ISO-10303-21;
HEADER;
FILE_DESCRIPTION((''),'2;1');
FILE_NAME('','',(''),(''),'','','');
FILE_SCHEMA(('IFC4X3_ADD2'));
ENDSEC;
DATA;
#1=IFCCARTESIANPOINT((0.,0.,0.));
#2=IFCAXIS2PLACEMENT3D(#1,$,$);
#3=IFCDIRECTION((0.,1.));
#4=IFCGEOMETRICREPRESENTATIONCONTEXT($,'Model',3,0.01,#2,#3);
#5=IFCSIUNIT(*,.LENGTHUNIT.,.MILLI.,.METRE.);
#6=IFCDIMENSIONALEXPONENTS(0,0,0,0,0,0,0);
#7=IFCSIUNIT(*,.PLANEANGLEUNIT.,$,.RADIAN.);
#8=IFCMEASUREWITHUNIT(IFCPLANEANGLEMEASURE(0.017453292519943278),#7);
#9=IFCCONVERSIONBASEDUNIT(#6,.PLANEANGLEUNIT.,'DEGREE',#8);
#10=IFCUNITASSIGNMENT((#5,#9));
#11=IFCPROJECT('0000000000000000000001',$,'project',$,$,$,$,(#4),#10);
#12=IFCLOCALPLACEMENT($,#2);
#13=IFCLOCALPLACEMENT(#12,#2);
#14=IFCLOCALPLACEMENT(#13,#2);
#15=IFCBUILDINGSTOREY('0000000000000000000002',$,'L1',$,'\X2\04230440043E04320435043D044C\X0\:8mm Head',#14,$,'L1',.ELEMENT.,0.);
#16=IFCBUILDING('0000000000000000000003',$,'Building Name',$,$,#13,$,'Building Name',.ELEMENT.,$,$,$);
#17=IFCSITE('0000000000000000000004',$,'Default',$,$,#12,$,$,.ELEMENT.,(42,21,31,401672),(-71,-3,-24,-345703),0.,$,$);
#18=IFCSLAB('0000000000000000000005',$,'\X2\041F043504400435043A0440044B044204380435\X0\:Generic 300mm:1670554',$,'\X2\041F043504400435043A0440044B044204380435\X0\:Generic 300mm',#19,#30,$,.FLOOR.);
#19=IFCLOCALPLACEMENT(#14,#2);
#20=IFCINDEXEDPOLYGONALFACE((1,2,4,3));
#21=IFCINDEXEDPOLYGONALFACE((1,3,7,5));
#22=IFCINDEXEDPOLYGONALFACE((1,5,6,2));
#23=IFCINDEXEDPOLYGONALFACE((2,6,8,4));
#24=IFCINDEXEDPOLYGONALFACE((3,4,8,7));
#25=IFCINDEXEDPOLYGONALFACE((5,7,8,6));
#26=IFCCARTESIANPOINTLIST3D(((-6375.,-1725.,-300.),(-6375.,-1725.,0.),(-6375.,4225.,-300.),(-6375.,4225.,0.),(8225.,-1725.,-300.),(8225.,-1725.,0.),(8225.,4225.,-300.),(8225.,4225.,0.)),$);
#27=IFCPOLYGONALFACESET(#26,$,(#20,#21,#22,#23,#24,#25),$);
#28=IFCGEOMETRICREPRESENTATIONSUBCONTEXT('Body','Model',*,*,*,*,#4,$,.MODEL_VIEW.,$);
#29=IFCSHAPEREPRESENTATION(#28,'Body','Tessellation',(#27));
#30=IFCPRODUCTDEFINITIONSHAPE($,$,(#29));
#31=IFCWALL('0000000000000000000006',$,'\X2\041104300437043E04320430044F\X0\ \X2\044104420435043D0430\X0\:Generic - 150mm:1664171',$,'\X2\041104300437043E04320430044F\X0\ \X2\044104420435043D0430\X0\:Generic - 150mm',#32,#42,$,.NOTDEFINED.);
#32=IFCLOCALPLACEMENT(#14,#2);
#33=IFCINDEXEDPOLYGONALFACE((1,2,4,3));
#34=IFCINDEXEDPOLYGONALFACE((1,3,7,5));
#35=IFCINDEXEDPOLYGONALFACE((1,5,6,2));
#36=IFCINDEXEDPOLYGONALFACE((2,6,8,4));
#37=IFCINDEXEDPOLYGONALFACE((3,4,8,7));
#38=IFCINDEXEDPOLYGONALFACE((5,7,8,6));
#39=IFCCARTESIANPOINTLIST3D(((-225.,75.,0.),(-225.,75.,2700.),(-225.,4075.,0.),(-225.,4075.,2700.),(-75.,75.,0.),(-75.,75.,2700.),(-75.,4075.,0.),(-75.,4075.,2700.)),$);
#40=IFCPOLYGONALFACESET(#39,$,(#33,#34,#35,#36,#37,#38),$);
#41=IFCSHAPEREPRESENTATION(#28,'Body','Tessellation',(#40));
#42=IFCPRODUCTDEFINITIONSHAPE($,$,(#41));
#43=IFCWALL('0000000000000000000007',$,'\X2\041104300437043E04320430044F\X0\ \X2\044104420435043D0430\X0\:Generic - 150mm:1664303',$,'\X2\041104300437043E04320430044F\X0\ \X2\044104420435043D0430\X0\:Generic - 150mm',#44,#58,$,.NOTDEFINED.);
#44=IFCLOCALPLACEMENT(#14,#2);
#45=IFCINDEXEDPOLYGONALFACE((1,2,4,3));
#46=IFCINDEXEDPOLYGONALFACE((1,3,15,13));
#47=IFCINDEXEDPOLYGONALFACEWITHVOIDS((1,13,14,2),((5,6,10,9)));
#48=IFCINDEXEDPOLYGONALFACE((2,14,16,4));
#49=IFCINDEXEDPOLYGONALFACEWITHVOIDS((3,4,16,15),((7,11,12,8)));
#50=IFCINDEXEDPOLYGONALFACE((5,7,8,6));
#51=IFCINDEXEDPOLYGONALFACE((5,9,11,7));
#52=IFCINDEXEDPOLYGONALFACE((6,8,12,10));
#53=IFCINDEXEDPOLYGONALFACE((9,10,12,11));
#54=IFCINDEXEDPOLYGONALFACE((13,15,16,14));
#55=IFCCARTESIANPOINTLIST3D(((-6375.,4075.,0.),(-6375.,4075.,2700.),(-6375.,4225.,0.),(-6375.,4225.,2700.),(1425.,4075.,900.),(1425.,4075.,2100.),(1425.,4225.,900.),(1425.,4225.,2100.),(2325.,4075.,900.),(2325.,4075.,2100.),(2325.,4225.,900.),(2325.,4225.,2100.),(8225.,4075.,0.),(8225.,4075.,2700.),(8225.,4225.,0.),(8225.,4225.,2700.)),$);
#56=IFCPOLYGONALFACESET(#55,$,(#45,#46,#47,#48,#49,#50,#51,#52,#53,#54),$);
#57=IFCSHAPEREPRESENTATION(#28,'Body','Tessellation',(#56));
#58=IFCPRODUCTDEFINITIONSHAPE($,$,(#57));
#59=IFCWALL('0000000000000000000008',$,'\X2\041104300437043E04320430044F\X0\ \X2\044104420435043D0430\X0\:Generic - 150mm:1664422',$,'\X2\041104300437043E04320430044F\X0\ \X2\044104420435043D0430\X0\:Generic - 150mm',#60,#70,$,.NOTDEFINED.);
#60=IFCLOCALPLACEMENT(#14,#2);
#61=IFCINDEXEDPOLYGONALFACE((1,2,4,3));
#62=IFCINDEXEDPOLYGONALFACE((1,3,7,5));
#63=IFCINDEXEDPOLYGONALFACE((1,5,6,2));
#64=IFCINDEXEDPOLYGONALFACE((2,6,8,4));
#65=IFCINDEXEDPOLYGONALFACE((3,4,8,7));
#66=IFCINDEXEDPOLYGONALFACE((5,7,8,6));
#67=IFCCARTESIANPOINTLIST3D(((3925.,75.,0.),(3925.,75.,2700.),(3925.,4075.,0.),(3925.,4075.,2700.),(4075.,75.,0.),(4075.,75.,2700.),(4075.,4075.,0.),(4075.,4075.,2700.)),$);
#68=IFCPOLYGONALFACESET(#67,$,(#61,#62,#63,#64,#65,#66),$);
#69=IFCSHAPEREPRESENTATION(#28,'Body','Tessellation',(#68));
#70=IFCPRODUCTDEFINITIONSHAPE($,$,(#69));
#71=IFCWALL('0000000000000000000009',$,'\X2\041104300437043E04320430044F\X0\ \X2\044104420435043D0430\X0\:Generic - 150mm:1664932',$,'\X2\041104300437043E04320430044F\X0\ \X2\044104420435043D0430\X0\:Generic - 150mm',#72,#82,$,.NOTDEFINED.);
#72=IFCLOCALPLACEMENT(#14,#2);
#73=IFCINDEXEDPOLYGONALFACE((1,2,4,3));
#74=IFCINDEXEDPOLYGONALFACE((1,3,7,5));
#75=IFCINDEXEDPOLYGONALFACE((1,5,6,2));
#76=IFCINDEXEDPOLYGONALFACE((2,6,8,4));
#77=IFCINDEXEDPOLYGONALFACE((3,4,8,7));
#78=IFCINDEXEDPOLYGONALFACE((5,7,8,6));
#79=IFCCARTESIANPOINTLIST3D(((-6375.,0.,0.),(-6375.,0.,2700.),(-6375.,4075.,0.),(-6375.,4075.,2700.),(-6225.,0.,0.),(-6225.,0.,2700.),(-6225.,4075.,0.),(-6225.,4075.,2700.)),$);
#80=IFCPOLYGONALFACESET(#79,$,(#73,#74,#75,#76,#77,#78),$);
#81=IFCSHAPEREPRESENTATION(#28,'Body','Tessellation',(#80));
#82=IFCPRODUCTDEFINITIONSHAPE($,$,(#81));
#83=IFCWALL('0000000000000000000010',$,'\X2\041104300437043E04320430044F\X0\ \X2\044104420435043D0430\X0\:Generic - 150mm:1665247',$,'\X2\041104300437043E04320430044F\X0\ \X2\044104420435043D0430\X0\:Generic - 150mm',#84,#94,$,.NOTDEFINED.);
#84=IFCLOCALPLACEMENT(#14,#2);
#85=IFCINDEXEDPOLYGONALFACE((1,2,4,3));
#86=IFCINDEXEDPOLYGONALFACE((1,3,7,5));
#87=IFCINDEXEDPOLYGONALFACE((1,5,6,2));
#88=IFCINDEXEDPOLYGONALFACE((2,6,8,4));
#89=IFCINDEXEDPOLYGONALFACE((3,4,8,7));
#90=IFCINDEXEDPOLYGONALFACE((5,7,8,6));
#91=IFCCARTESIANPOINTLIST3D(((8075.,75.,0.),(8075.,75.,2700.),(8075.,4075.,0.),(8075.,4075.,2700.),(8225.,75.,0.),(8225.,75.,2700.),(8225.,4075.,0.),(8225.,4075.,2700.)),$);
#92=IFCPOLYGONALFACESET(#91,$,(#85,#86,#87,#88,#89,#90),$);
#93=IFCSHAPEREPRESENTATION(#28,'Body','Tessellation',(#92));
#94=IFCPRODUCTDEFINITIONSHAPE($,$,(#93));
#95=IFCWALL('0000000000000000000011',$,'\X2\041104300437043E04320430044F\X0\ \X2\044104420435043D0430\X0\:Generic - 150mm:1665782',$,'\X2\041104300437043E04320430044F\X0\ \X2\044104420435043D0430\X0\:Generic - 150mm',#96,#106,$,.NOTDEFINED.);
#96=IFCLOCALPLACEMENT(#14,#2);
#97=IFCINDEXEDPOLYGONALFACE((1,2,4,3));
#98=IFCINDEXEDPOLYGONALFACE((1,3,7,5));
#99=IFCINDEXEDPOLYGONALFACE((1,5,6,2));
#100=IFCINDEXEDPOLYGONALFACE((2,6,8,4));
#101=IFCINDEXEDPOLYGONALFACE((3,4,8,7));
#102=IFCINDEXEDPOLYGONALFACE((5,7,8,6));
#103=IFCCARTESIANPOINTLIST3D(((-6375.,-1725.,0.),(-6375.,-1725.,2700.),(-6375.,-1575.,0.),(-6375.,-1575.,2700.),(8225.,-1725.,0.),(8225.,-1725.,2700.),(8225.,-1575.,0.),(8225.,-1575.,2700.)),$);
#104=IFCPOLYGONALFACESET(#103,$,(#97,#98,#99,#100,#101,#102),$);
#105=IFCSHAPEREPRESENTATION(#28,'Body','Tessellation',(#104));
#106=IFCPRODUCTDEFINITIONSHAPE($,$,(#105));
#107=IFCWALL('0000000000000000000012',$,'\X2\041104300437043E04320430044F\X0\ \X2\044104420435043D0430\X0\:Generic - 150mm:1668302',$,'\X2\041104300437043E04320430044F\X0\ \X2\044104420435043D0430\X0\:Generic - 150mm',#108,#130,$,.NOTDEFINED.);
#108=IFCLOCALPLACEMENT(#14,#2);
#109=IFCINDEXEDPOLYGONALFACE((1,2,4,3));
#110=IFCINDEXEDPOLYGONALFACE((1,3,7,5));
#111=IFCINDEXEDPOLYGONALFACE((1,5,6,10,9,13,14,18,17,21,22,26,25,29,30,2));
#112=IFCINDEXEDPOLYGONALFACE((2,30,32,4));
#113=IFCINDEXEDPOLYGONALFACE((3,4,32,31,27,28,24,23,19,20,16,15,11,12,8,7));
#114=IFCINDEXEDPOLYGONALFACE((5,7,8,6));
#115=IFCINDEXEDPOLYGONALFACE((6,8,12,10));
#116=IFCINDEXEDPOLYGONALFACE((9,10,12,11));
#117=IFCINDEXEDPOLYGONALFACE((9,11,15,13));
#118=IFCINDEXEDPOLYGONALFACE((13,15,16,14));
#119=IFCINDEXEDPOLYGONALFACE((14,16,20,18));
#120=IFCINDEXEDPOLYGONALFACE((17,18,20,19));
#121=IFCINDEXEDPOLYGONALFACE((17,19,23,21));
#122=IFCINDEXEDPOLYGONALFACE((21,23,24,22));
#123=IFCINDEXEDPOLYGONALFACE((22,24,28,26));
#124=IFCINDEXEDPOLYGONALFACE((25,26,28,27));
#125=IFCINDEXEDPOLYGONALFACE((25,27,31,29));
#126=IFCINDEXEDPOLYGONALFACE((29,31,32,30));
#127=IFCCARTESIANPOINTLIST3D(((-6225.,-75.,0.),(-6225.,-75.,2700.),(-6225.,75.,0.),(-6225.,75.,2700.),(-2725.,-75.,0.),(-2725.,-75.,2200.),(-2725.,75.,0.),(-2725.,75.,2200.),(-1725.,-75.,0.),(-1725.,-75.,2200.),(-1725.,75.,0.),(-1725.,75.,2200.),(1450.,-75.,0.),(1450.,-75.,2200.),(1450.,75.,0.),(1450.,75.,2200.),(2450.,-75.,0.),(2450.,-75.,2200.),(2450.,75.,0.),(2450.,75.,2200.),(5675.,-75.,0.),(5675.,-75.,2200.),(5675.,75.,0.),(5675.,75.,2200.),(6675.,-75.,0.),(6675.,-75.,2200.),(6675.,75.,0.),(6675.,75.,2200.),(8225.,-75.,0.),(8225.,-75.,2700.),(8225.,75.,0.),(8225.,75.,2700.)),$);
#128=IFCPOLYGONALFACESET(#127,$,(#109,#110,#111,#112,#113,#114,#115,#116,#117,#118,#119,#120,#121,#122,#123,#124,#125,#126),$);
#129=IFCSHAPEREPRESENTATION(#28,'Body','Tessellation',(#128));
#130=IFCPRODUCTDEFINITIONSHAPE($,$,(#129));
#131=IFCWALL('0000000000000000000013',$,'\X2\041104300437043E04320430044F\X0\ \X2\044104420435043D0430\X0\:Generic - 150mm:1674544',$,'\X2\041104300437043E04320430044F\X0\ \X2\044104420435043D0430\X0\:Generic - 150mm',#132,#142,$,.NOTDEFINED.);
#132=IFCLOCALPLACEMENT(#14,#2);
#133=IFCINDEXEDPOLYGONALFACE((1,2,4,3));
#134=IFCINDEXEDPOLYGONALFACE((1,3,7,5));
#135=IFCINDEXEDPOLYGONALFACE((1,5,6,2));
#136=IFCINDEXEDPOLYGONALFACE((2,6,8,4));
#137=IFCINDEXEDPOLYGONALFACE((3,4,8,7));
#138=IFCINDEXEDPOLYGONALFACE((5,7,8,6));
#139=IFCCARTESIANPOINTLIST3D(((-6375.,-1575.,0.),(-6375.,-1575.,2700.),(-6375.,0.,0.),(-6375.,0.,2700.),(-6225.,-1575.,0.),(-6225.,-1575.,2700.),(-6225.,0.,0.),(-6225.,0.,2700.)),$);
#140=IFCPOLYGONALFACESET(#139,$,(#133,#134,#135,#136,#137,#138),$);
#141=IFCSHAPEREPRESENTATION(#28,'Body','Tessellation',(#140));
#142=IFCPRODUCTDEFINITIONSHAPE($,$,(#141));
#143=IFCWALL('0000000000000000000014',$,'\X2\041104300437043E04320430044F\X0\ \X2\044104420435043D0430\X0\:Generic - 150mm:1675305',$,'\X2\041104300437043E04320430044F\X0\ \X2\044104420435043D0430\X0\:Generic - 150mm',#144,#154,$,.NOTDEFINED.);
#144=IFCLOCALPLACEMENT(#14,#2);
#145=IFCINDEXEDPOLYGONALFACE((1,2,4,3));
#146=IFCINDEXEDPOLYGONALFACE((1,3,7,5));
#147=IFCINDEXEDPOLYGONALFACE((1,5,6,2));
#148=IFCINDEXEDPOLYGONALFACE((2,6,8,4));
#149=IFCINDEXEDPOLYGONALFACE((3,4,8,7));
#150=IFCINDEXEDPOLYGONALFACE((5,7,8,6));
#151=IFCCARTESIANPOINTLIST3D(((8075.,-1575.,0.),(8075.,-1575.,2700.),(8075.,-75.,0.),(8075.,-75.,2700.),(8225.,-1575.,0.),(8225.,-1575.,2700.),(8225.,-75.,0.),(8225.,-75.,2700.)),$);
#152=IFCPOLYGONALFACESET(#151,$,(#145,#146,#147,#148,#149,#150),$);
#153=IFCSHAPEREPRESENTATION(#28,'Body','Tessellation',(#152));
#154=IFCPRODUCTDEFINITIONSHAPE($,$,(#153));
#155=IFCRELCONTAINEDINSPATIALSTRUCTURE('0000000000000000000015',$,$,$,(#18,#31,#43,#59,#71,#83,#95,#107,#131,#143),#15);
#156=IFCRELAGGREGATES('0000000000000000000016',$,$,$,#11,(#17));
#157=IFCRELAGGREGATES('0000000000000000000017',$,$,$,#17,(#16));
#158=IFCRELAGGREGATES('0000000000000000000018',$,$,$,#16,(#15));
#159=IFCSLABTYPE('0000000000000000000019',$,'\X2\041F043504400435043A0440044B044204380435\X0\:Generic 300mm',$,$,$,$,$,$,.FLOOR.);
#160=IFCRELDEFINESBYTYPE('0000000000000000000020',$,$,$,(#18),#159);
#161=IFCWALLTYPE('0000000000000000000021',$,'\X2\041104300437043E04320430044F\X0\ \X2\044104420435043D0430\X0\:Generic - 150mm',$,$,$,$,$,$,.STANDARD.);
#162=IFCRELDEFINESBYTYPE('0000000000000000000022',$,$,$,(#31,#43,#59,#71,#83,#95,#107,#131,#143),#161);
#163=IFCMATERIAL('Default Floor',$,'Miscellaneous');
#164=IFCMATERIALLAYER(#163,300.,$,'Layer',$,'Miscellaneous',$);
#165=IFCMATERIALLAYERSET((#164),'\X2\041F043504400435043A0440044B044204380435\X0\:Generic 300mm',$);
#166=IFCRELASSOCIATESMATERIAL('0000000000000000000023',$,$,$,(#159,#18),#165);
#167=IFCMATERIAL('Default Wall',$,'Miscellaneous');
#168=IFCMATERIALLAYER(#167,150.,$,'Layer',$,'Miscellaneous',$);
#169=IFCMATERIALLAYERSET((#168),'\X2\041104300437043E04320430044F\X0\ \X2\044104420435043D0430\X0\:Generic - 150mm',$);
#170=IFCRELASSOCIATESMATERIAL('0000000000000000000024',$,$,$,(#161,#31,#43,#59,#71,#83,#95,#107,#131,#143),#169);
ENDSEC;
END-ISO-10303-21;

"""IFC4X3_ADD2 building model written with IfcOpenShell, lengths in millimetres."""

from ifc_helpers import new_model, entity, si_unit, converted_unit, direction, frame, frame_2d, origin, origin_2d_with_axis, place, context, subcontext, project, spatial, rectangle, extrude, material, layer, layer_set, layer_usage, type_object, element, save


model = new_model("IFC4X3_ADD2")

# Units and contexts
model_context = context("Model", 3, precision=0.01, world=origin(), true_north=direction((0.0, 1.0)))
body_context = subcontext(model_context, "Body", "Model", "MODEL_VIEW")
ifc_project = project(units=[si_unit("LENGTHUNIT", "METRE", prefix="MILLI"), converted_unit("PLANEANGLEUNIT", "DEGREE", entity("IfcPlaneAngleMeasure", 0.017453292519943278), si_unit("PLANEANGLEUNIT", "RADIAN"), dimensions=[0, 0, 0, 0, 0, 0, 0])], contexts=[model_context])

# Site, building, storey
site_placement = place(None, origin())
site = spatial("IfcSite", under=ifc_project, at=site_placement, Name="Default", CompositionType="ELEMENT", RefLatitude=(42, 21, 31, 401672), RefLongitude=(-71, -3, -24, -345703), RefElevation=0.0)
building_placement = place(site_placement, origin())
building = spatial("IfcBuilding", under=site, at=building_placement, Name="Building Name", LongName="Building Name", CompositionType="ELEMENT")
storey_placement = place(building_placement, origin())
storey = spatial("IfcBuildingStorey", under=building, at=storey_placement, Name="L1", ObjectType="Уровень:8mm Head", LongName="L1", CompositionType="ELEMENT", Elevation=0.0)

# Slab
ifc_material_1 = material(Name="Default Floor", Category="Miscellaneous")
ifc_layer_1 = layer(ifc_material_1, 300.0, Name="Layer", Category="Miscellaneous")
ifc_layer_set_1 = layer_set([ifc_layer_1], Name="Перекрытие:Generic 300mm")
ifc_layer_usage = layer_usage(ifc_layer_set_1, "AXIS3", "POSITIVE", 0.0)
slab_type = type_object("IfcSlabType", Name="Перекрытие:Generic 300mm", PredefinedType="FLOOR", material=ifc_layer_set_1)
slab_placement = place(storey_placement, origin())
element("IfcSlab", 1, at=slab_placement, inside=storey, type_object=slab_type, material=ifc_layer_usage, Name="Перекрытие:Generic 300mm:1670554", ObjectType="Перекрытие:Generic 300mm", PredefinedType="FLOOR", context=body_context, shape_type="SweptSolid", body=[
    extrude(rectangle(XDim=5950.0, YDim=14600.0, at=origin_2d_with_axis()), frame((925.0, 1250.0, 0.0), z_axis=(0.0, 0.0, -1.0), x_axis=(0.0, 1.0, 0.0)), (0.0, 0.0, 1.0), 300.0),
])

# Wall
ifc_material_2 = material(Name="Default Wall", Category="Miscellaneous")
ifc_layer_2 = layer(ifc_material_2, 150.0, Name="Layer", Category="Miscellaneous")
ifc_layer_set_2 = layer_set([ifc_layer_2], Name="Базовая стена:Generic - 150mm")
wall_type = type_object("IfcWallType", Name="Базовая стена:Generic - 150mm", PredefinedType="STANDARD", material=ifc_layer_set_2)
wall_1_placement = place(storey_placement, frame((-150.0, 75.0, 0.0), z_axis=(0.0, 0.0, 1.0), x_axis=(0.0, 1.0, 0.0)))
element("IfcWall", 2, at=wall_1_placement, inside=storey, type_object=wall_type, material=ifc_layer_set_2, Name="Базовая стена:Generic - 150mm:1664171", ObjectType="Базовая стена:Generic - 150mm", PredefinedType="NOTDEFINED", context=body_context, shape_type="SweptSolid", body=[
    extrude(rectangle(XDim=4000.0, YDim=150.0, at=frame_2d((2000.0, 0.0), x_axis=(-1.0, 0.0))), origin(), (0.0, 0.0, 1.0), 2700.0),
])

# Wall, opening
wall_2_placement = place(storey_placement, frame((-6375.0, 4150.0, 0.0)))
wall_2 = element("IfcWall", 3, at=wall_2_placement, inside=storey, type_object=wall_type, material=ifc_layer_set_2, Name="Базовая стена:Generic - 150mm:1664303", ObjectType="Базовая стена:Generic - 150mm", PredefinedType="NOTDEFINED", context=body_context, shape_type="SweptSolid", body=[
    extrude(rectangle(XDim=14600.0, YDim=150.0, at=frame_2d((7300.0, 0.0), x_axis=(-1.0, 0.0))), origin(), (0.0, 0.0, 1.0), 2700.0),
])
opening_1_placement = place(wall_2_placement, frame((7800.0, -75.0, 900.0)))
element("IfcOpeningElement", 4, at=opening_1_placement, cuts=wall_2, PredefinedType="OPENING", context=body_context, shape_type="SweptSolid", body=[
    extrude(rectangle(XDim=1200.0, YDim=900.0, at=frame_2d((600.0, 450.0), x_axis=(-1.0, 0.0))), frame((0.0, 0.0, 0.0), z_axis=(0.0, 1.0, 0.0), x_axis=(0.0, 0.0, 1.0)), (0.0, 0.0, 1.0), 150.0),
])

# Walls
wall_3_placement = place(storey_placement, frame((4000.0, 4075.0, 0.0), z_axis=(0.0, 0.0, 1.0), x_axis=(0.0, -1.0, 0.0)))
element("IfcWall", 5, at=wall_3_placement, inside=storey, type_object=wall_type, material=ifc_layer_set_2, Name="Базовая стена:Generic - 150mm:1664422", ObjectType="Базовая стена:Generic - 150mm", PredefinedType="NOTDEFINED", context=body_context, shape_type="SweptSolid", body=[
    extrude(rectangle(XDim=4000.0, YDim=150.0, at=frame_2d((2000.0, 0.0), x_axis=(-1.0, 0.0))), origin(), (0.0, 0.0, 1.0), 2700.0),
])
wall_4_placement = place(storey_placement, frame((-6300.0, 4075.0, 0.0), z_axis=(0.0, 0.0, 1.0), x_axis=(0.0, -1.0, 0.0)))
element("IfcWall", 6, at=wall_4_placement, inside=storey, type_object=wall_type, material=ifc_layer_set_2, Name="Базовая стена:Generic - 150mm:1664932", ObjectType="Базовая стена:Generic - 150mm", PredefinedType="NOTDEFINED", context=body_context, shape_type="SweptSolid", body=[
    extrude(rectangle(XDim=4075.0, YDim=150.0, at=frame_2d((2037.5, 0.0), x_axis=(-1.0, 0.0))), origin(), (0.0, 0.0, 1.0), 2700.0),
])
wall_5_placement = place(storey_placement, frame((8150.0, 4075.0, 0.0), z_axis=(0.0, 0.0, 1.0), x_axis=(0.0, -1.0, 0.0)))
element("IfcWall", 7, at=wall_5_placement, inside=storey, type_object=wall_type, material=ifc_layer_set_2, Name="Базовая стена:Generic - 150mm:1665247", ObjectType="Базовая стена:Generic - 150mm", PredefinedType="NOTDEFINED", context=body_context, shape_type="SweptSolid", body=[
    extrude(rectangle(XDim=4000.0, YDim=150.0, at=frame_2d((2000.0, 0.0), x_axis=(-1.0, 0.0))), origin(), (0.0, 0.0, 1.0), 2700.0),
])
wall_6_placement = place(storey_placement, frame((8225.0, -1650.0, 0.0), z_axis=(0.0, 0.0, 1.0), x_axis=(-1.0, 0.0, 0.0)))
element("IfcWall", 8, at=wall_6_placement, inside=storey, type_object=wall_type, material=ifc_layer_set_2, Name="Базовая стена:Generic - 150mm:1665782", ObjectType="Базовая стена:Generic - 150mm", PredefinedType="NOTDEFINED", context=body_context, shape_type="SweptSolid", body=[
    extrude(rectangle(XDim=14600.0, YDim=150.0, at=frame_2d((7300.0, 0.0), x_axis=(-1.0, 0.0))), origin(), (0.0, 0.0, 1.0), 2700.0),
])

# Wall, openings
wall_7_placement = place(storey_placement, frame((8225.0, 0.0, 0.0), z_axis=(0.0, 0.0, 1.0), x_axis=(-1.0, 0.0, 0.0)))
wall_7 = element("IfcWall", 9, at=wall_7_placement, inside=storey, type_object=wall_type, material=ifc_layer_set_2, Name="Базовая стена:Generic - 150mm:1668302", ObjectType="Базовая стена:Generic - 150mm", PredefinedType="NOTDEFINED", context=body_context, shape_type="SweptSolid", body=[
    extrude(rectangle(XDim=14450.0, YDim=150.0, at=frame_2d((7225.0, 0.0), x_axis=(-1.0, 0.0))), origin(), (0.0, 0.0, 1.0), 2700.0),
])
opening_2_placement = place(wall_7_placement, frame((6775.0, 75.0, 0.0)))
element("IfcOpeningElement", 10, at=opening_2_placement, cuts=wall_7, PredefinedType="OPENING", context=body_context, shape_type="SweptSolid", body=[
    extrude(rectangle(XDim=2200.0, YDim=1000.0, at=frame_2d((1100.0, 500.0), x_axis=(1.0, 0.0))), frame((0.0, 0.0, 0.0), z_axis=(0.0, -1.0, 0.0), x_axis=(0.0, 0.0, 1.0)), (0.0, 0.0, 1.0), 150.0),
])
opening_3_placement = place(wall_7_placement, frame((8225.0, 0.0, 0.0), z_axis=(0.0, 0.0, 1.0), x_axis=(-1.0, 0.0, 0.0)))
element("IfcOpeningElement", 11, at=opening_3_placement, cuts=wall_7, PredefinedType="OPENING", context=body_context, shape_type="SweptSolid", body=[
    extrude(rectangle(XDim=2200.0, YDim=1000.0, at=frame_2d((0.0, 0.0), x_axis=(1.0, 0.0))), frame((1950.0, 1449.0, 1100.0), z_axis=(0.0, -1.0, 0.0), x_axis=(0.0, 0.0, 1.0)), (0.0, 0.0, 1.0), 3048.0),
])
opening_4_placement = place(wall_7_placement, frame((10950.0, 75.0, 0.0)))
element("IfcOpeningElement", 12, at=opening_4_placement, cuts=wall_7, PredefinedType="OPENING", context=body_context, shape_type="SweptSolid", body=[
    extrude(rectangle(XDim=2200.0, YDim=1000.0, at=frame_2d((1100.0, 500.0), x_axis=(1.0, 0.0))), frame((0.0, 0.0, 0.0), z_axis=(0.0, -1.0, 0.0), x_axis=(0.0, 0.0, 1.0)), (0.0, 0.0, 1.0), 150.0),
])
opening_5_placement = place(wall_7_placement, frame((1550.0, -75.0, 0.0)))
element("IfcOpeningElement", 13, at=opening_5_placement, cuts=wall_7, PredefinedType="OPENING", context=body_context, shape_type="SweptSolid", body=[
    extrude(rectangle(XDim=2200.0, YDim=1000.0, at=frame_2d((1100.0, 500.0), x_axis=(1.0, 0.0))), frame((0.0, 0.0, 0.0), z_axis=(0.0, 1.0, 0.0), x_axis=(0.0, 0.0, 1.0)), (0.0, 0.0, 1.0), 150.0),
])

# Walls
wall_8_placement = place(storey_placement, frame((-6300.0, 0.0, 0.0), z_axis=(0.0, 0.0, 1.0), x_axis=(0.0, -1.0, 0.0)))
element("IfcWall", 14, at=wall_8_placement, inside=storey, type_object=wall_type, material=ifc_layer_set_2, Name="Базовая стена:Generic - 150mm:1674544", ObjectType="Базовая стена:Generic - 150mm", PredefinedType="NOTDEFINED", context=body_context, shape_type="SweptSolid", body=[
    extrude(rectangle(XDim=1575.0, YDim=150.0, at=frame_2d((787.5, 0.0), x_axis=(-1.0, 0.0))), origin(), (0.0, 0.0, 1.0), 2700.0),
])
wall_9_placement = place(storey_placement, frame((8150.0, -75.0, 0.0), z_axis=(0.0, 0.0, 1.0), x_axis=(0.0, -1.0, 0.0)))
element("IfcWall", 15, at=wall_9_placement, inside=storey, type_object=wall_type, material=ifc_layer_set_2, Name="Базовая стена:Generic - 150mm:1675305", ObjectType="Базовая стена:Generic - 150mm", PredefinedType="NOTDEFINED", context=body_context, shape_type="SweptSolid", body=[
    extrude(rectangle(XDim=1500.0, YDim=150.0, at=frame_2d((750.0, 0.0), x_axis=(-1.0, 0.0))), origin(), (0.0, 0.0, 1.0), 2700.0),
])

save(model, "model.ifc")
